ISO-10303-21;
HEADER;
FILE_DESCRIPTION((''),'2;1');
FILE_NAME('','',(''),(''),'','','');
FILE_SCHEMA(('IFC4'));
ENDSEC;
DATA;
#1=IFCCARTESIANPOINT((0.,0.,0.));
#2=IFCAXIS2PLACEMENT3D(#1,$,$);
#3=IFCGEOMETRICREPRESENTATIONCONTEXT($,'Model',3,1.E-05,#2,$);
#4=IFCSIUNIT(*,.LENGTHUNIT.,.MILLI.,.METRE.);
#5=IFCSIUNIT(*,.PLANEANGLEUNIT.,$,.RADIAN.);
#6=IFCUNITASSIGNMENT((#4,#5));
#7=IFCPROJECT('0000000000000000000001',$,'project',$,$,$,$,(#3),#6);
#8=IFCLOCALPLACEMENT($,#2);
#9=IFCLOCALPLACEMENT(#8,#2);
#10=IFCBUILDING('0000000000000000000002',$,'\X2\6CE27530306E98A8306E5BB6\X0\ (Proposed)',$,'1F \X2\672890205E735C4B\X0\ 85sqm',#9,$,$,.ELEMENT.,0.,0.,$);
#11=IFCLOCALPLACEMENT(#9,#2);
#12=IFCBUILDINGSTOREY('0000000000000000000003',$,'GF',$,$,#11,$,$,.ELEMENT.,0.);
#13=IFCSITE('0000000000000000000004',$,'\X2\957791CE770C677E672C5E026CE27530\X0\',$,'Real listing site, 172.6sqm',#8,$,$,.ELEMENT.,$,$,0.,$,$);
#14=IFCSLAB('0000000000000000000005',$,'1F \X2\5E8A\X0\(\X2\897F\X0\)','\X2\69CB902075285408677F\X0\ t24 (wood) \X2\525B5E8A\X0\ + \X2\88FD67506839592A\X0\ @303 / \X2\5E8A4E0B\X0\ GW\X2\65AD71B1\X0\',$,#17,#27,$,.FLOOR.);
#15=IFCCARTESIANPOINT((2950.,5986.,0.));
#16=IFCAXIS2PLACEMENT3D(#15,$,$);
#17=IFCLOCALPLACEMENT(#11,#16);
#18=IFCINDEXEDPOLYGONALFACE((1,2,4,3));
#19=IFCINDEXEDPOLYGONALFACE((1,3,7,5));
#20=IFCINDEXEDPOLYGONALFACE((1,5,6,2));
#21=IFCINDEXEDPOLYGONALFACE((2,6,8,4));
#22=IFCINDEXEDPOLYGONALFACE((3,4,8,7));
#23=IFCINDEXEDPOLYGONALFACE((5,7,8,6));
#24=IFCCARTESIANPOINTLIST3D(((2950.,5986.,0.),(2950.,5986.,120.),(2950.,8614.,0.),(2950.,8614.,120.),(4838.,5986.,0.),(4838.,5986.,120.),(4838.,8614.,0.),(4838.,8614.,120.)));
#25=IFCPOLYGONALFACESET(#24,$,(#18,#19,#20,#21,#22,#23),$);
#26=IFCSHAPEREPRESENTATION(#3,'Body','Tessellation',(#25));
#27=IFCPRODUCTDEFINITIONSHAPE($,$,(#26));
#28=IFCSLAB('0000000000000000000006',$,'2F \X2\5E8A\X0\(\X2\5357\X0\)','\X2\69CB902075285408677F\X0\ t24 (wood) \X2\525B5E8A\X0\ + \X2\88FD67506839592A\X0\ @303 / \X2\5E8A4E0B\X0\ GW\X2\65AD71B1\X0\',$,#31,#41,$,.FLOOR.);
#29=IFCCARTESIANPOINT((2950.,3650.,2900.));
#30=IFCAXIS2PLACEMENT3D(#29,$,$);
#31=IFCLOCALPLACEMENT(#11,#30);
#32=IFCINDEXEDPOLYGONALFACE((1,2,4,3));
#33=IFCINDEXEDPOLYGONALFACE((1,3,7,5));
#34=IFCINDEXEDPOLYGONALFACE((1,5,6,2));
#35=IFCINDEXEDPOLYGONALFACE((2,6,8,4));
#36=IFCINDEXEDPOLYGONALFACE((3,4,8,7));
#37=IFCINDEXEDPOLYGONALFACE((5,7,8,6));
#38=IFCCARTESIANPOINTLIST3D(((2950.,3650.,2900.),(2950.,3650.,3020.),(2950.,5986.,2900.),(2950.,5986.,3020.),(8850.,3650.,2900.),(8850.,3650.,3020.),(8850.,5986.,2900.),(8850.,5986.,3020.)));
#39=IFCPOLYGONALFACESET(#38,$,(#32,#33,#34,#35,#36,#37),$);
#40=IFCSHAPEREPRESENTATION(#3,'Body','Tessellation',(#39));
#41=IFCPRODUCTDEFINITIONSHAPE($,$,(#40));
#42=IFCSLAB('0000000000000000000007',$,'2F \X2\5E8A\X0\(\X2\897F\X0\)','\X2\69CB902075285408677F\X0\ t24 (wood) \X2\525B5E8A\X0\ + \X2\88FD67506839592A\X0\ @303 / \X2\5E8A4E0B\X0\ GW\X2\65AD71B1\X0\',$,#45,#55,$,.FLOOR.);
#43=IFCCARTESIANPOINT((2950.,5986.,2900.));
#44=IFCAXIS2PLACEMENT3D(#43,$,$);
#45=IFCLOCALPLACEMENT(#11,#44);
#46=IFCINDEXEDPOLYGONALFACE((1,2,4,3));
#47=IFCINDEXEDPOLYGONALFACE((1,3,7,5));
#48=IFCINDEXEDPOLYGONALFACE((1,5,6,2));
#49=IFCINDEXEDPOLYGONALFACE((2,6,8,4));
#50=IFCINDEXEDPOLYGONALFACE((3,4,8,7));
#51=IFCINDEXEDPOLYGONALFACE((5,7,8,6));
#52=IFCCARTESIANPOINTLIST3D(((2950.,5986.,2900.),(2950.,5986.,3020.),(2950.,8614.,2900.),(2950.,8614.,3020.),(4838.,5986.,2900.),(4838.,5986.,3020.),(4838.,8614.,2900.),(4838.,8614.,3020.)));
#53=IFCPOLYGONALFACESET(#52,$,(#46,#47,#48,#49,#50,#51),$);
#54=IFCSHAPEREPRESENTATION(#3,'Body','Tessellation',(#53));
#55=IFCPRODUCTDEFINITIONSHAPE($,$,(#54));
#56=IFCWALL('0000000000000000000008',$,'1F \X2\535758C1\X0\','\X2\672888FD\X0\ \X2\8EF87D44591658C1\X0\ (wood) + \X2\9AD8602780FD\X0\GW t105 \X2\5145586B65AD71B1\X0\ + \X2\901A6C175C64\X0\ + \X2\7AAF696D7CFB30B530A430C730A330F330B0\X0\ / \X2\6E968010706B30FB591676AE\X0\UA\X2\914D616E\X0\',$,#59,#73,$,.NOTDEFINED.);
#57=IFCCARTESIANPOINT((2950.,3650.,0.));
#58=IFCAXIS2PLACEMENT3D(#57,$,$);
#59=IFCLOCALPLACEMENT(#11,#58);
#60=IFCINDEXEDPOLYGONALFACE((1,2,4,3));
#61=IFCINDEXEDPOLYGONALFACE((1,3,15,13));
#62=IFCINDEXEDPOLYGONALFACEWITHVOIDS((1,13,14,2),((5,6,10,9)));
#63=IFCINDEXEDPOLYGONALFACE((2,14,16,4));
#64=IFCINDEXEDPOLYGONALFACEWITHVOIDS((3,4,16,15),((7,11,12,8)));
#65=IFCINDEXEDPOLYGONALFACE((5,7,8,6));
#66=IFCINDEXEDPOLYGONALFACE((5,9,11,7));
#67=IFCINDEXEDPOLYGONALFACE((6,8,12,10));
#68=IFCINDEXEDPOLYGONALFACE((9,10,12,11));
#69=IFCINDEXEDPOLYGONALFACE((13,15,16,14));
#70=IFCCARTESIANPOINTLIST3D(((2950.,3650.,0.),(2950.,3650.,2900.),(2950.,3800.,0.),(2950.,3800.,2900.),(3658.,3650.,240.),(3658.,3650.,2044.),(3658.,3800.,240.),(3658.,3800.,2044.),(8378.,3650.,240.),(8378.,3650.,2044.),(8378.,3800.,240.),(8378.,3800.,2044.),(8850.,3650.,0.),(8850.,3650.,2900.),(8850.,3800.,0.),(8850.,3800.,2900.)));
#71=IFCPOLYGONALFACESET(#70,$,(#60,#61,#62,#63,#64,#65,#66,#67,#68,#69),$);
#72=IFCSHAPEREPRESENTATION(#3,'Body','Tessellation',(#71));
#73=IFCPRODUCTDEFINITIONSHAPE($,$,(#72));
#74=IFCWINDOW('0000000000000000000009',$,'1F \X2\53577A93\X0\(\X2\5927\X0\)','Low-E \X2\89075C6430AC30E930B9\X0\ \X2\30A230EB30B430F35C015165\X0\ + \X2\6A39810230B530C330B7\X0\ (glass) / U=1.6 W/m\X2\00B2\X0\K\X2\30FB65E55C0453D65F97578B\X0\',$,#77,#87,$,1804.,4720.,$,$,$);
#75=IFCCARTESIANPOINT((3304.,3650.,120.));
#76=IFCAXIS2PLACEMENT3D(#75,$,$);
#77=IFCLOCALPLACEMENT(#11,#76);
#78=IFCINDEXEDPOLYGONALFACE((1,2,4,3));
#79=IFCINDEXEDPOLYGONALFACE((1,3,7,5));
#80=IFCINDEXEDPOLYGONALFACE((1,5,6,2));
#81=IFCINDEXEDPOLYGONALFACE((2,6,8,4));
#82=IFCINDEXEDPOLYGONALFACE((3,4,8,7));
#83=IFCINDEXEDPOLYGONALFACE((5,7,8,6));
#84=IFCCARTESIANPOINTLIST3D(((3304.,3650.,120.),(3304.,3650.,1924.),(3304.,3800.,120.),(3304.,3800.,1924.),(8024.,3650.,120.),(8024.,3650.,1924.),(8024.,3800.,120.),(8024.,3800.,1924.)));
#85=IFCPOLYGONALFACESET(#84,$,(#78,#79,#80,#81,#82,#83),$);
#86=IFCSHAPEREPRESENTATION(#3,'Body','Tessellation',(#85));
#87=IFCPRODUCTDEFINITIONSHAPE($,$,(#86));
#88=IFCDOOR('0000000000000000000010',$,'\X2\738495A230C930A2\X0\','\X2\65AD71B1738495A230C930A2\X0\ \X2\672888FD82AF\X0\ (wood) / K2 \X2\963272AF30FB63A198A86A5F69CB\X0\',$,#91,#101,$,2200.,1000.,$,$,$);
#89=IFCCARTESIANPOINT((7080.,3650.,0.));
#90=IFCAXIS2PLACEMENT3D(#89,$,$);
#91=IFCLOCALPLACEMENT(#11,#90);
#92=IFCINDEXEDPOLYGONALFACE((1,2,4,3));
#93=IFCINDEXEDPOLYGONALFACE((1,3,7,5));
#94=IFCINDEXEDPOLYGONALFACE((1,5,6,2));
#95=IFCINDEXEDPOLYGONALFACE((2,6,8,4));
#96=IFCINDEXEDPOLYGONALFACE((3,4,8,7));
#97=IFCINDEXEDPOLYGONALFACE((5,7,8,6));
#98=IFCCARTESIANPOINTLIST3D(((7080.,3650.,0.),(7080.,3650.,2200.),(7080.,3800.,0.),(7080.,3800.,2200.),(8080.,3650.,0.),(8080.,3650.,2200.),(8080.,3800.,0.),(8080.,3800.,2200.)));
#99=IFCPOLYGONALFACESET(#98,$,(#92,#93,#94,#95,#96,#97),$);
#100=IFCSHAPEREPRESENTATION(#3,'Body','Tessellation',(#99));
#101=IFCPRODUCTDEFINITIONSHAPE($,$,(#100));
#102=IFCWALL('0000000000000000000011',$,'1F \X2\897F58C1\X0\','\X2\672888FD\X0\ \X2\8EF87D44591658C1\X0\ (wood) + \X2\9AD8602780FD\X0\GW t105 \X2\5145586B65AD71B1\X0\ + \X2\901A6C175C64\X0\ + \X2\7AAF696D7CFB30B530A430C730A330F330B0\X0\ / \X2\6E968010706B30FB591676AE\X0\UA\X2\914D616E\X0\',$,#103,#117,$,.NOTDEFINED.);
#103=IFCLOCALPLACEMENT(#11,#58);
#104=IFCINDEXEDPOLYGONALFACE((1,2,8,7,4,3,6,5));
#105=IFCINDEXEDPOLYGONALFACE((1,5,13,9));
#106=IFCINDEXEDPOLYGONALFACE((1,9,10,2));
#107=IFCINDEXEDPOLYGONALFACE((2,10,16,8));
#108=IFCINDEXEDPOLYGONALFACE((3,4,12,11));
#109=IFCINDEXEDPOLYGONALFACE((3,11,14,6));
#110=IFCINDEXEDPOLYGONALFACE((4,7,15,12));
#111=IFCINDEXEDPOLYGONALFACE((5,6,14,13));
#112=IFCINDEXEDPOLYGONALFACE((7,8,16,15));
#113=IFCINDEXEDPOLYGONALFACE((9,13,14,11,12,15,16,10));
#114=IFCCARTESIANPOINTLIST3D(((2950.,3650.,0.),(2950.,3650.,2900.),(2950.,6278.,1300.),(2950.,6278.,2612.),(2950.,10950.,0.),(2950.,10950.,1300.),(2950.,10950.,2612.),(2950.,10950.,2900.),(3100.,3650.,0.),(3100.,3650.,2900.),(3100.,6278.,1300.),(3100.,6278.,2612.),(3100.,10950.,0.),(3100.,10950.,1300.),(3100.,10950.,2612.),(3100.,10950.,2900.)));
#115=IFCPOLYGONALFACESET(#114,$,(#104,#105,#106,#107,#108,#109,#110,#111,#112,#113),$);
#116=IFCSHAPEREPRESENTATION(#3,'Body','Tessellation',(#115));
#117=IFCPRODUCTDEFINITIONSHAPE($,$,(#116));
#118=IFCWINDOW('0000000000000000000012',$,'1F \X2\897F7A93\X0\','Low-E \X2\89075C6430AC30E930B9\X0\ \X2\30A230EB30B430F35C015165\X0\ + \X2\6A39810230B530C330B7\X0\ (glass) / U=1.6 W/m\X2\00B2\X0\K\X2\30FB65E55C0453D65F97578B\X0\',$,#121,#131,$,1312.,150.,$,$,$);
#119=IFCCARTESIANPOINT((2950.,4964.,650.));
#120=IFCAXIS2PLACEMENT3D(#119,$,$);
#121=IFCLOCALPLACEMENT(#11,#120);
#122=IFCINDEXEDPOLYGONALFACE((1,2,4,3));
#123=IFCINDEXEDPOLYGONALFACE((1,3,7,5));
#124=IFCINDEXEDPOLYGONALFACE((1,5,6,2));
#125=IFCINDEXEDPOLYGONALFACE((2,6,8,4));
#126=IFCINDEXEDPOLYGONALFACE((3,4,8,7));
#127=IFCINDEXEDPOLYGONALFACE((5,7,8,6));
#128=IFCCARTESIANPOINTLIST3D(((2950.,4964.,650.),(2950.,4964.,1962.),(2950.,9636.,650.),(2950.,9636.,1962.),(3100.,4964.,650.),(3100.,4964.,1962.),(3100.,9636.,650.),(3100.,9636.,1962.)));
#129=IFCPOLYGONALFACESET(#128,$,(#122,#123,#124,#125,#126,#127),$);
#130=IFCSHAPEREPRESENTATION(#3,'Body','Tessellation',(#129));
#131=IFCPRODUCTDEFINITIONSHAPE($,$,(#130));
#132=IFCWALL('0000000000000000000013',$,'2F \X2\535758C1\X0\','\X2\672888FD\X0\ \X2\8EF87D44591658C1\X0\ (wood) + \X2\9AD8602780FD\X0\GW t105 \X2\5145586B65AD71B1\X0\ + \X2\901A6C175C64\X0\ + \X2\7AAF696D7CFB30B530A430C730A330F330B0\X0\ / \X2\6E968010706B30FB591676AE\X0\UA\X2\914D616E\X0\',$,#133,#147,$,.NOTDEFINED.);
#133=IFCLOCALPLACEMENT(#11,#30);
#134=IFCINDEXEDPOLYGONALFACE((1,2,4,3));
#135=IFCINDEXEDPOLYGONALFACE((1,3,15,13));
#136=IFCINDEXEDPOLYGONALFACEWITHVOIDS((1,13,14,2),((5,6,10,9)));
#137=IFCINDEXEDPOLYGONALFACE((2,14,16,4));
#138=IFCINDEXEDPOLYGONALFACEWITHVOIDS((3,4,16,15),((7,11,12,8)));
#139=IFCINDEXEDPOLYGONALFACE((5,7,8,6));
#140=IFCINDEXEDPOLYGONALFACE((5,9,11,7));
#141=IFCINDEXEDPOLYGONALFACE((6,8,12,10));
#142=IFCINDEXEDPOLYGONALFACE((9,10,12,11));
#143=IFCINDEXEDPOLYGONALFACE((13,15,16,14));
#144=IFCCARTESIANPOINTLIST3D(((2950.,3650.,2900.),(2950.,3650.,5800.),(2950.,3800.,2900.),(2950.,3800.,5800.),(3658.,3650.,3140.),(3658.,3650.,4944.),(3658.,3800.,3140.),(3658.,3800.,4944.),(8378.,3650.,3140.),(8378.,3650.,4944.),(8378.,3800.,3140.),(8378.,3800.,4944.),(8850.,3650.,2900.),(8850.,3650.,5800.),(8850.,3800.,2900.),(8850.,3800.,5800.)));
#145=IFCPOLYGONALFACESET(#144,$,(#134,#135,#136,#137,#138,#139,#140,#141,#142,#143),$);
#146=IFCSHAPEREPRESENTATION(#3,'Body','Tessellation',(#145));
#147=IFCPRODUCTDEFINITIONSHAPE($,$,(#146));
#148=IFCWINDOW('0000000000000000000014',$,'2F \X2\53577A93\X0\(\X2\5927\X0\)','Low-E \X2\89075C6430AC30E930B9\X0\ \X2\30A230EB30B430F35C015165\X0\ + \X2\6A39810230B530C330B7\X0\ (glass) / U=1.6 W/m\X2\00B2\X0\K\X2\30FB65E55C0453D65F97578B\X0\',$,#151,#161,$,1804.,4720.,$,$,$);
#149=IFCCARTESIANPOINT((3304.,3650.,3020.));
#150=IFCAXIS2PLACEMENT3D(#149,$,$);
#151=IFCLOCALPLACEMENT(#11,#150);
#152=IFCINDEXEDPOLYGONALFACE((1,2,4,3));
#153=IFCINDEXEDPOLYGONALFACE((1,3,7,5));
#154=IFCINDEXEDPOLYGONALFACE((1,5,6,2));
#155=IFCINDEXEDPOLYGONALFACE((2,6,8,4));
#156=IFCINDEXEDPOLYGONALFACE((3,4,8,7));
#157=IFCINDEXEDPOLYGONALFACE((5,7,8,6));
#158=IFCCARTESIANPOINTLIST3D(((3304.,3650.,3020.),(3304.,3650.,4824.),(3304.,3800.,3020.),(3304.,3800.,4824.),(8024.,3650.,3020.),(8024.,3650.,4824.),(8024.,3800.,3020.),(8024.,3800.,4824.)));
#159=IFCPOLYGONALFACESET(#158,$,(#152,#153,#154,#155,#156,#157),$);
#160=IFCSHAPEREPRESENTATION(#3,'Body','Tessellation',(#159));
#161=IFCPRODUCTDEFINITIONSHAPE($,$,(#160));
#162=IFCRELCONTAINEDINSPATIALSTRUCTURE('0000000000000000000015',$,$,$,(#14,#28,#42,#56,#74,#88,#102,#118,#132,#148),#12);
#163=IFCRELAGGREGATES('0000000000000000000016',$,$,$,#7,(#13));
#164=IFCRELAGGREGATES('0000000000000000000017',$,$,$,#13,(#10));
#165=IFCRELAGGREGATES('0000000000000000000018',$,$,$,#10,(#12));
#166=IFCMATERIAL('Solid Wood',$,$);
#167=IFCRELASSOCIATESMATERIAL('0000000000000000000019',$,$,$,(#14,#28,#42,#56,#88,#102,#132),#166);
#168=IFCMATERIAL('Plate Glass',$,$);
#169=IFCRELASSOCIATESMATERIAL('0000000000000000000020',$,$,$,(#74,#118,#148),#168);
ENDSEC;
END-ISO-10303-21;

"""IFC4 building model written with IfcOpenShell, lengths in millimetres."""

from ifc_helpers import new_model, si_unit, frame, frame_2d, origin, place, context, project, spatial, rectangle, extrude, material, element, fill, save


model = new_model("IFC4")

# Units and contexts
model_context = context("Model", 3, precision=1e-05, world=origin())
ifc_project = project(units=[si_unit("LENGTHUNIT", "METRE", prefix="MILLI"), si_unit("PLANEANGLEUNIT", "RADIAN")], contexts=[model_context])

# Site, building, storey
site_placement = place(None, origin())
site = spatial("IfcSite", under=ifc_project, at=site_placement, Name="長野県松本市波田", ObjectType="Real listing site, 172.6sqm", CompositionType="ELEMENT", RefElevation=0.0)
building_placement = place(site_placement, origin())
building = spatial("IfcBuilding", under=site, at=building_placement, Name="波田の風の家 (Proposed)", ObjectType="1F 木造平屋 85sqm", CompositionType="ELEMENT", ElevationOfRefHeight=0.0, ElevationOfTerrain=0.0)
storey_placement = place(building_placement, origin())
storey = spatial("IfcBuildingStorey", under=building, at=storey_placement, Name="GF", CompositionType="ELEMENT", Elevation=0.0)

# Slabs
ifc_material_1 = material(Name="Solid Wood")
slab_1_placement = place(storey_placement, frame((2950.0, 5986.0, 0.0)))
element("IfcSlab", 1, at=slab_1_placement, inside=storey, material=ifc_material_1, Name="1F 床(西)", Description="構造用合板 t24 (wood) 剛床 + 製材根太 @303 / 床下 GW断熱", PredefinedType="FLOOR", context=model_context, shape_type="SweptSolid", body=[
    extrude(rectangle(XDim=1888.0, YDim=2628.0, at=frame_2d((944.0, 1314.0))), frame((2950.0, 5986.0, 0.0)), (0.0, 0.0, 1.0), 120.0),
])
slab_2_placement = place(storey_placement, frame((2950.0, 3650.0, 2900.0)))
element("IfcSlab", 2, at=slab_2_placement, inside=storey, material=ifc_material_1, Name="2F 床(南)", Description="構造用合板 t24 (wood) 剛床 + 製材根太 @303 / 床下 GW断熱", PredefinedType="FLOOR", context=model_context, shape_type="SweptSolid", body=[
    extrude(rectangle(XDim=5900.0, YDim=2336.0, at=frame_2d((2950.0, 1168.0))), frame((2950.0, 3650.0, 2900.0)), (0.0, 0.0, 1.0), 120.0),
])
slab_3_placement = place(storey_placement, frame((2950.0, 5986.0, 2900.0)))
element("IfcSlab", 3, at=slab_3_placement, inside=storey, material=ifc_material_1, Name="2F 床(西)", Description="構造用合板 t24 (wood) 剛床 + 製材根太 @303 / 床下 GW断熱", PredefinedType="FLOOR", context=model_context, shape_type="SweptSolid", body=[
    extrude(rectangle(XDim=1888.0, YDim=2628.0, at=frame_2d((944.0, 1314.0))), frame((2950.0, 5986.0, 2900.0)), (0.0, 0.0, 1.0), 120.0),
])

# Wall, openings, window, door
wall_1_placement = place(storey_placement, frame((2950.0, 3650.0, 0.0)))
wall_1 = element("IfcWall", 4, at=wall_1_placement, inside=storey, material=ifc_material_1, Name="1F 南壁", Description="木製 軸組外壁 (wood) + 高性能GW t105 充填断熱 + 通気層 + 窯業系サイディング / 準耐火・外皮UA配慮", PredefinedType="NOTDEFINED", context=model_context, shape_type="SweptSolid", body=[
    extrude(rectangle(XDim=5900.0, YDim=150.0, at=frame_2d((2950.0, 75.0))), frame((2950.0, 3650.0, 0.0)), (0.0, 0.0, 1.0), 2900.0),
])
opening_1_placement = place(storey_placement, frame((3304.0, 3650.0, 120.0)))
opening_1 = element("IfcOpeningElement", 5, at=opening_1_placement, cuts=wall_1, PredefinedType="NOTDEFINED", context=model_context, shape_type="SweptSolid", body=[
    extrude(rectangle(XDim=4720.0, YDim=150.0, at=frame_2d((2360.0, 75.0))), frame((3304.0, 3650.0, 120.0)), (0.0, 0.0, 1.0), 1804.0),
])
opening_2_placement = place(storey_placement, frame((7080.0, 3650.0, 0.0)))
opening_2 = element("IfcOpeningElement", 6, at=opening_2_placement, cuts=wall_1, PredefinedType="NOTDEFINED", context=model_context, shape_type="SweptSolid", body=[
    extrude(rectangle(XDim=1000.0, YDim=150.0, at=frame_2d((500.0, 75.0))), frame((7080.0, 3650.0, 0.0)), (0.0, 0.0, 1.0), 2200.0),
])
ifc_material_2 = material(Name="Plate Glass")
window_1_placement = place(storey_placement, frame((3304.0, 3650.0, 120.0)))
window_1 = element("IfcWindow", 7, at=window_1_placement, inside=storey, material=ifc_material_2, Name="1F 南窓(大)", Description="Low-E 複層ガラス アルゴン封入 + 樹脂サッシ (glass) / U=1.6 W/m²K・日射取得型", OverallHeight=1804.0, OverallWidth=4720.0, context=model_context, shape_type="SweptSolid", body=[
    extrude(rectangle(XDim=4720.0, YDim=150.0, at=frame_2d((2360.0, 75.0))), frame((3304.0, 3650.0, 120.0)), (0.0, 0.0, 1.0), 1804.0),
])
fill(opening_1, window_1)
door_placement = place(storey_placement, frame((7080.0, 3650.0, 0.0)))
door = element("IfcDoor", 8, at=door_placement, inside=storey, material=ifc_material_1, Name="玄関ドア", Description="断熱玄関ドア 木製芯 (wood) / K2 防犯・採風機構", OverallHeight=2200.0, OverallWidth=1000.0, context=model_context, shape_type="SweptSolid", body=[
    extrude(rectangle(XDim=1000.0, YDim=150.0, at=frame_2d((500.0, 75.0))), frame((7080.0, 3650.0, 0.0)), (0.0, 0.0, 1.0), 2200.0),
])
fill(opening_2, door)

# Walls, openings, windows
wall_2_placement = place(storey_placement, frame((2950.0, 3650.0, 0.0)))
wall_2 = element("IfcWall", 9, at=wall_2_placement, inside=storey, material=ifc_material_1, Name="1F 西壁", Description="木製 軸組外壁 (wood) + 高性能GW t105 充填断熱 + 通気層 + 窯業系サイディング / 準耐火・外皮UA配慮", PredefinedType="NOTDEFINED", context=model_context, shape_type="SweptSolid", body=[
    extrude(rectangle(XDim=150.0, YDim=7300.0, at=frame_2d((75.0, 3650.0))), frame((2950.0, 3650.0, 0.0)), (0.0, 0.0, 1.0), 2900.0),
])
opening_3_placement = place(storey_placement, frame((2950.0, 4964.0, 650.0)))
opening_3 = element("IfcOpeningElement", 10, at=opening_3_placement, cuts=wall_2, PredefinedType="NOTDEFINED", context=model_context, shape_type="SweptSolid", body=[
    extrude(rectangle(XDim=150.0, YDim=4672.0, at=frame_2d((75.0, 2336.0))), frame((2950.0, 4964.0, 650.0)), (0.0, 0.0, 1.0), 1312.0),
])
window_2_placement = place(storey_placement, frame((2950.0, 4964.0, 650.0)))
window_2 = element("IfcWindow", 11, at=window_2_placement, inside=storey, material=ifc_material_2, Name="1F 西窓", Description="Low-E 複層ガラス アルゴン封入 + 樹脂サッシ (glass) / U=1.6 W/m²K・日射取得型", OverallHeight=1312.0, OverallWidth=150.0, context=model_context, shape_type="SweptSolid", body=[
    extrude(rectangle(XDim=150.0, YDim=4672.0, at=frame_2d((75.0, 2336.0))), frame((2950.0, 4964.0, 650.0)), (0.0, 0.0, 1.0), 1312.0),
])
fill(opening_3, window_2)
wall_3_placement = place(storey_placement, frame((2950.0, 3650.0, 2900.0)))
wall_3 = element("IfcWall", 12, at=wall_3_placement, inside=storey, material=ifc_material_1, Name="2F 南壁", Description="木製 軸組外壁 (wood) + 高性能GW t105 充填断熱 + 通気層 + 窯業系サイディング / 準耐火・外皮UA配慮", PredefinedType="NOTDEFINED", context=model_context, shape_type="SweptSolid", body=[
    extrude(rectangle(XDim=5900.0, YDim=150.0, at=frame_2d((2950.0, 75.0))), frame((2950.0, 3650.0, 2900.0)), (0.0, 0.0, 1.0), 2900.0),
])
opening_4_placement = place(storey_placement, frame((3304.0, 3650.0, 3020.0)))
opening_4 = element("IfcOpeningElement", 13, at=opening_4_placement, cuts=wall_3, PredefinedType="NOTDEFINED", context=model_context, shape_type="SweptSolid", body=[
    extrude(rectangle(XDim=4720.0, YDim=150.0, at=frame_2d((2360.0, 75.0))), frame((3304.0, 3650.0, 3020.0)), (0.0, 0.0, 1.0), 1804.0),
])
window_3_placement = place(storey_placement, frame((3304.0, 3650.0, 3020.0)))
window_3 = element("IfcWindow", 14, at=window_3_placement, inside=storey, material=ifc_material_2, Name="2F 南窓(大)", Description="Low-E 複層ガラス アルゴン封入 + 樹脂サッシ (glass) / U=1.6 W/m²K・日射取得型", OverallHeight=1804.0, OverallWidth=4720.0, context=model_context, shape_type="SweptSolid", body=[
    extrude(rectangle(XDim=4720.0, YDim=150.0, at=frame_2d((2360.0, 75.0))), frame((3304.0, 3650.0, 3020.0)), (0.0, 0.0, 1.0), 1804.0),
])
fill(opening_4, window_3)

save(model, "model.ifc")
